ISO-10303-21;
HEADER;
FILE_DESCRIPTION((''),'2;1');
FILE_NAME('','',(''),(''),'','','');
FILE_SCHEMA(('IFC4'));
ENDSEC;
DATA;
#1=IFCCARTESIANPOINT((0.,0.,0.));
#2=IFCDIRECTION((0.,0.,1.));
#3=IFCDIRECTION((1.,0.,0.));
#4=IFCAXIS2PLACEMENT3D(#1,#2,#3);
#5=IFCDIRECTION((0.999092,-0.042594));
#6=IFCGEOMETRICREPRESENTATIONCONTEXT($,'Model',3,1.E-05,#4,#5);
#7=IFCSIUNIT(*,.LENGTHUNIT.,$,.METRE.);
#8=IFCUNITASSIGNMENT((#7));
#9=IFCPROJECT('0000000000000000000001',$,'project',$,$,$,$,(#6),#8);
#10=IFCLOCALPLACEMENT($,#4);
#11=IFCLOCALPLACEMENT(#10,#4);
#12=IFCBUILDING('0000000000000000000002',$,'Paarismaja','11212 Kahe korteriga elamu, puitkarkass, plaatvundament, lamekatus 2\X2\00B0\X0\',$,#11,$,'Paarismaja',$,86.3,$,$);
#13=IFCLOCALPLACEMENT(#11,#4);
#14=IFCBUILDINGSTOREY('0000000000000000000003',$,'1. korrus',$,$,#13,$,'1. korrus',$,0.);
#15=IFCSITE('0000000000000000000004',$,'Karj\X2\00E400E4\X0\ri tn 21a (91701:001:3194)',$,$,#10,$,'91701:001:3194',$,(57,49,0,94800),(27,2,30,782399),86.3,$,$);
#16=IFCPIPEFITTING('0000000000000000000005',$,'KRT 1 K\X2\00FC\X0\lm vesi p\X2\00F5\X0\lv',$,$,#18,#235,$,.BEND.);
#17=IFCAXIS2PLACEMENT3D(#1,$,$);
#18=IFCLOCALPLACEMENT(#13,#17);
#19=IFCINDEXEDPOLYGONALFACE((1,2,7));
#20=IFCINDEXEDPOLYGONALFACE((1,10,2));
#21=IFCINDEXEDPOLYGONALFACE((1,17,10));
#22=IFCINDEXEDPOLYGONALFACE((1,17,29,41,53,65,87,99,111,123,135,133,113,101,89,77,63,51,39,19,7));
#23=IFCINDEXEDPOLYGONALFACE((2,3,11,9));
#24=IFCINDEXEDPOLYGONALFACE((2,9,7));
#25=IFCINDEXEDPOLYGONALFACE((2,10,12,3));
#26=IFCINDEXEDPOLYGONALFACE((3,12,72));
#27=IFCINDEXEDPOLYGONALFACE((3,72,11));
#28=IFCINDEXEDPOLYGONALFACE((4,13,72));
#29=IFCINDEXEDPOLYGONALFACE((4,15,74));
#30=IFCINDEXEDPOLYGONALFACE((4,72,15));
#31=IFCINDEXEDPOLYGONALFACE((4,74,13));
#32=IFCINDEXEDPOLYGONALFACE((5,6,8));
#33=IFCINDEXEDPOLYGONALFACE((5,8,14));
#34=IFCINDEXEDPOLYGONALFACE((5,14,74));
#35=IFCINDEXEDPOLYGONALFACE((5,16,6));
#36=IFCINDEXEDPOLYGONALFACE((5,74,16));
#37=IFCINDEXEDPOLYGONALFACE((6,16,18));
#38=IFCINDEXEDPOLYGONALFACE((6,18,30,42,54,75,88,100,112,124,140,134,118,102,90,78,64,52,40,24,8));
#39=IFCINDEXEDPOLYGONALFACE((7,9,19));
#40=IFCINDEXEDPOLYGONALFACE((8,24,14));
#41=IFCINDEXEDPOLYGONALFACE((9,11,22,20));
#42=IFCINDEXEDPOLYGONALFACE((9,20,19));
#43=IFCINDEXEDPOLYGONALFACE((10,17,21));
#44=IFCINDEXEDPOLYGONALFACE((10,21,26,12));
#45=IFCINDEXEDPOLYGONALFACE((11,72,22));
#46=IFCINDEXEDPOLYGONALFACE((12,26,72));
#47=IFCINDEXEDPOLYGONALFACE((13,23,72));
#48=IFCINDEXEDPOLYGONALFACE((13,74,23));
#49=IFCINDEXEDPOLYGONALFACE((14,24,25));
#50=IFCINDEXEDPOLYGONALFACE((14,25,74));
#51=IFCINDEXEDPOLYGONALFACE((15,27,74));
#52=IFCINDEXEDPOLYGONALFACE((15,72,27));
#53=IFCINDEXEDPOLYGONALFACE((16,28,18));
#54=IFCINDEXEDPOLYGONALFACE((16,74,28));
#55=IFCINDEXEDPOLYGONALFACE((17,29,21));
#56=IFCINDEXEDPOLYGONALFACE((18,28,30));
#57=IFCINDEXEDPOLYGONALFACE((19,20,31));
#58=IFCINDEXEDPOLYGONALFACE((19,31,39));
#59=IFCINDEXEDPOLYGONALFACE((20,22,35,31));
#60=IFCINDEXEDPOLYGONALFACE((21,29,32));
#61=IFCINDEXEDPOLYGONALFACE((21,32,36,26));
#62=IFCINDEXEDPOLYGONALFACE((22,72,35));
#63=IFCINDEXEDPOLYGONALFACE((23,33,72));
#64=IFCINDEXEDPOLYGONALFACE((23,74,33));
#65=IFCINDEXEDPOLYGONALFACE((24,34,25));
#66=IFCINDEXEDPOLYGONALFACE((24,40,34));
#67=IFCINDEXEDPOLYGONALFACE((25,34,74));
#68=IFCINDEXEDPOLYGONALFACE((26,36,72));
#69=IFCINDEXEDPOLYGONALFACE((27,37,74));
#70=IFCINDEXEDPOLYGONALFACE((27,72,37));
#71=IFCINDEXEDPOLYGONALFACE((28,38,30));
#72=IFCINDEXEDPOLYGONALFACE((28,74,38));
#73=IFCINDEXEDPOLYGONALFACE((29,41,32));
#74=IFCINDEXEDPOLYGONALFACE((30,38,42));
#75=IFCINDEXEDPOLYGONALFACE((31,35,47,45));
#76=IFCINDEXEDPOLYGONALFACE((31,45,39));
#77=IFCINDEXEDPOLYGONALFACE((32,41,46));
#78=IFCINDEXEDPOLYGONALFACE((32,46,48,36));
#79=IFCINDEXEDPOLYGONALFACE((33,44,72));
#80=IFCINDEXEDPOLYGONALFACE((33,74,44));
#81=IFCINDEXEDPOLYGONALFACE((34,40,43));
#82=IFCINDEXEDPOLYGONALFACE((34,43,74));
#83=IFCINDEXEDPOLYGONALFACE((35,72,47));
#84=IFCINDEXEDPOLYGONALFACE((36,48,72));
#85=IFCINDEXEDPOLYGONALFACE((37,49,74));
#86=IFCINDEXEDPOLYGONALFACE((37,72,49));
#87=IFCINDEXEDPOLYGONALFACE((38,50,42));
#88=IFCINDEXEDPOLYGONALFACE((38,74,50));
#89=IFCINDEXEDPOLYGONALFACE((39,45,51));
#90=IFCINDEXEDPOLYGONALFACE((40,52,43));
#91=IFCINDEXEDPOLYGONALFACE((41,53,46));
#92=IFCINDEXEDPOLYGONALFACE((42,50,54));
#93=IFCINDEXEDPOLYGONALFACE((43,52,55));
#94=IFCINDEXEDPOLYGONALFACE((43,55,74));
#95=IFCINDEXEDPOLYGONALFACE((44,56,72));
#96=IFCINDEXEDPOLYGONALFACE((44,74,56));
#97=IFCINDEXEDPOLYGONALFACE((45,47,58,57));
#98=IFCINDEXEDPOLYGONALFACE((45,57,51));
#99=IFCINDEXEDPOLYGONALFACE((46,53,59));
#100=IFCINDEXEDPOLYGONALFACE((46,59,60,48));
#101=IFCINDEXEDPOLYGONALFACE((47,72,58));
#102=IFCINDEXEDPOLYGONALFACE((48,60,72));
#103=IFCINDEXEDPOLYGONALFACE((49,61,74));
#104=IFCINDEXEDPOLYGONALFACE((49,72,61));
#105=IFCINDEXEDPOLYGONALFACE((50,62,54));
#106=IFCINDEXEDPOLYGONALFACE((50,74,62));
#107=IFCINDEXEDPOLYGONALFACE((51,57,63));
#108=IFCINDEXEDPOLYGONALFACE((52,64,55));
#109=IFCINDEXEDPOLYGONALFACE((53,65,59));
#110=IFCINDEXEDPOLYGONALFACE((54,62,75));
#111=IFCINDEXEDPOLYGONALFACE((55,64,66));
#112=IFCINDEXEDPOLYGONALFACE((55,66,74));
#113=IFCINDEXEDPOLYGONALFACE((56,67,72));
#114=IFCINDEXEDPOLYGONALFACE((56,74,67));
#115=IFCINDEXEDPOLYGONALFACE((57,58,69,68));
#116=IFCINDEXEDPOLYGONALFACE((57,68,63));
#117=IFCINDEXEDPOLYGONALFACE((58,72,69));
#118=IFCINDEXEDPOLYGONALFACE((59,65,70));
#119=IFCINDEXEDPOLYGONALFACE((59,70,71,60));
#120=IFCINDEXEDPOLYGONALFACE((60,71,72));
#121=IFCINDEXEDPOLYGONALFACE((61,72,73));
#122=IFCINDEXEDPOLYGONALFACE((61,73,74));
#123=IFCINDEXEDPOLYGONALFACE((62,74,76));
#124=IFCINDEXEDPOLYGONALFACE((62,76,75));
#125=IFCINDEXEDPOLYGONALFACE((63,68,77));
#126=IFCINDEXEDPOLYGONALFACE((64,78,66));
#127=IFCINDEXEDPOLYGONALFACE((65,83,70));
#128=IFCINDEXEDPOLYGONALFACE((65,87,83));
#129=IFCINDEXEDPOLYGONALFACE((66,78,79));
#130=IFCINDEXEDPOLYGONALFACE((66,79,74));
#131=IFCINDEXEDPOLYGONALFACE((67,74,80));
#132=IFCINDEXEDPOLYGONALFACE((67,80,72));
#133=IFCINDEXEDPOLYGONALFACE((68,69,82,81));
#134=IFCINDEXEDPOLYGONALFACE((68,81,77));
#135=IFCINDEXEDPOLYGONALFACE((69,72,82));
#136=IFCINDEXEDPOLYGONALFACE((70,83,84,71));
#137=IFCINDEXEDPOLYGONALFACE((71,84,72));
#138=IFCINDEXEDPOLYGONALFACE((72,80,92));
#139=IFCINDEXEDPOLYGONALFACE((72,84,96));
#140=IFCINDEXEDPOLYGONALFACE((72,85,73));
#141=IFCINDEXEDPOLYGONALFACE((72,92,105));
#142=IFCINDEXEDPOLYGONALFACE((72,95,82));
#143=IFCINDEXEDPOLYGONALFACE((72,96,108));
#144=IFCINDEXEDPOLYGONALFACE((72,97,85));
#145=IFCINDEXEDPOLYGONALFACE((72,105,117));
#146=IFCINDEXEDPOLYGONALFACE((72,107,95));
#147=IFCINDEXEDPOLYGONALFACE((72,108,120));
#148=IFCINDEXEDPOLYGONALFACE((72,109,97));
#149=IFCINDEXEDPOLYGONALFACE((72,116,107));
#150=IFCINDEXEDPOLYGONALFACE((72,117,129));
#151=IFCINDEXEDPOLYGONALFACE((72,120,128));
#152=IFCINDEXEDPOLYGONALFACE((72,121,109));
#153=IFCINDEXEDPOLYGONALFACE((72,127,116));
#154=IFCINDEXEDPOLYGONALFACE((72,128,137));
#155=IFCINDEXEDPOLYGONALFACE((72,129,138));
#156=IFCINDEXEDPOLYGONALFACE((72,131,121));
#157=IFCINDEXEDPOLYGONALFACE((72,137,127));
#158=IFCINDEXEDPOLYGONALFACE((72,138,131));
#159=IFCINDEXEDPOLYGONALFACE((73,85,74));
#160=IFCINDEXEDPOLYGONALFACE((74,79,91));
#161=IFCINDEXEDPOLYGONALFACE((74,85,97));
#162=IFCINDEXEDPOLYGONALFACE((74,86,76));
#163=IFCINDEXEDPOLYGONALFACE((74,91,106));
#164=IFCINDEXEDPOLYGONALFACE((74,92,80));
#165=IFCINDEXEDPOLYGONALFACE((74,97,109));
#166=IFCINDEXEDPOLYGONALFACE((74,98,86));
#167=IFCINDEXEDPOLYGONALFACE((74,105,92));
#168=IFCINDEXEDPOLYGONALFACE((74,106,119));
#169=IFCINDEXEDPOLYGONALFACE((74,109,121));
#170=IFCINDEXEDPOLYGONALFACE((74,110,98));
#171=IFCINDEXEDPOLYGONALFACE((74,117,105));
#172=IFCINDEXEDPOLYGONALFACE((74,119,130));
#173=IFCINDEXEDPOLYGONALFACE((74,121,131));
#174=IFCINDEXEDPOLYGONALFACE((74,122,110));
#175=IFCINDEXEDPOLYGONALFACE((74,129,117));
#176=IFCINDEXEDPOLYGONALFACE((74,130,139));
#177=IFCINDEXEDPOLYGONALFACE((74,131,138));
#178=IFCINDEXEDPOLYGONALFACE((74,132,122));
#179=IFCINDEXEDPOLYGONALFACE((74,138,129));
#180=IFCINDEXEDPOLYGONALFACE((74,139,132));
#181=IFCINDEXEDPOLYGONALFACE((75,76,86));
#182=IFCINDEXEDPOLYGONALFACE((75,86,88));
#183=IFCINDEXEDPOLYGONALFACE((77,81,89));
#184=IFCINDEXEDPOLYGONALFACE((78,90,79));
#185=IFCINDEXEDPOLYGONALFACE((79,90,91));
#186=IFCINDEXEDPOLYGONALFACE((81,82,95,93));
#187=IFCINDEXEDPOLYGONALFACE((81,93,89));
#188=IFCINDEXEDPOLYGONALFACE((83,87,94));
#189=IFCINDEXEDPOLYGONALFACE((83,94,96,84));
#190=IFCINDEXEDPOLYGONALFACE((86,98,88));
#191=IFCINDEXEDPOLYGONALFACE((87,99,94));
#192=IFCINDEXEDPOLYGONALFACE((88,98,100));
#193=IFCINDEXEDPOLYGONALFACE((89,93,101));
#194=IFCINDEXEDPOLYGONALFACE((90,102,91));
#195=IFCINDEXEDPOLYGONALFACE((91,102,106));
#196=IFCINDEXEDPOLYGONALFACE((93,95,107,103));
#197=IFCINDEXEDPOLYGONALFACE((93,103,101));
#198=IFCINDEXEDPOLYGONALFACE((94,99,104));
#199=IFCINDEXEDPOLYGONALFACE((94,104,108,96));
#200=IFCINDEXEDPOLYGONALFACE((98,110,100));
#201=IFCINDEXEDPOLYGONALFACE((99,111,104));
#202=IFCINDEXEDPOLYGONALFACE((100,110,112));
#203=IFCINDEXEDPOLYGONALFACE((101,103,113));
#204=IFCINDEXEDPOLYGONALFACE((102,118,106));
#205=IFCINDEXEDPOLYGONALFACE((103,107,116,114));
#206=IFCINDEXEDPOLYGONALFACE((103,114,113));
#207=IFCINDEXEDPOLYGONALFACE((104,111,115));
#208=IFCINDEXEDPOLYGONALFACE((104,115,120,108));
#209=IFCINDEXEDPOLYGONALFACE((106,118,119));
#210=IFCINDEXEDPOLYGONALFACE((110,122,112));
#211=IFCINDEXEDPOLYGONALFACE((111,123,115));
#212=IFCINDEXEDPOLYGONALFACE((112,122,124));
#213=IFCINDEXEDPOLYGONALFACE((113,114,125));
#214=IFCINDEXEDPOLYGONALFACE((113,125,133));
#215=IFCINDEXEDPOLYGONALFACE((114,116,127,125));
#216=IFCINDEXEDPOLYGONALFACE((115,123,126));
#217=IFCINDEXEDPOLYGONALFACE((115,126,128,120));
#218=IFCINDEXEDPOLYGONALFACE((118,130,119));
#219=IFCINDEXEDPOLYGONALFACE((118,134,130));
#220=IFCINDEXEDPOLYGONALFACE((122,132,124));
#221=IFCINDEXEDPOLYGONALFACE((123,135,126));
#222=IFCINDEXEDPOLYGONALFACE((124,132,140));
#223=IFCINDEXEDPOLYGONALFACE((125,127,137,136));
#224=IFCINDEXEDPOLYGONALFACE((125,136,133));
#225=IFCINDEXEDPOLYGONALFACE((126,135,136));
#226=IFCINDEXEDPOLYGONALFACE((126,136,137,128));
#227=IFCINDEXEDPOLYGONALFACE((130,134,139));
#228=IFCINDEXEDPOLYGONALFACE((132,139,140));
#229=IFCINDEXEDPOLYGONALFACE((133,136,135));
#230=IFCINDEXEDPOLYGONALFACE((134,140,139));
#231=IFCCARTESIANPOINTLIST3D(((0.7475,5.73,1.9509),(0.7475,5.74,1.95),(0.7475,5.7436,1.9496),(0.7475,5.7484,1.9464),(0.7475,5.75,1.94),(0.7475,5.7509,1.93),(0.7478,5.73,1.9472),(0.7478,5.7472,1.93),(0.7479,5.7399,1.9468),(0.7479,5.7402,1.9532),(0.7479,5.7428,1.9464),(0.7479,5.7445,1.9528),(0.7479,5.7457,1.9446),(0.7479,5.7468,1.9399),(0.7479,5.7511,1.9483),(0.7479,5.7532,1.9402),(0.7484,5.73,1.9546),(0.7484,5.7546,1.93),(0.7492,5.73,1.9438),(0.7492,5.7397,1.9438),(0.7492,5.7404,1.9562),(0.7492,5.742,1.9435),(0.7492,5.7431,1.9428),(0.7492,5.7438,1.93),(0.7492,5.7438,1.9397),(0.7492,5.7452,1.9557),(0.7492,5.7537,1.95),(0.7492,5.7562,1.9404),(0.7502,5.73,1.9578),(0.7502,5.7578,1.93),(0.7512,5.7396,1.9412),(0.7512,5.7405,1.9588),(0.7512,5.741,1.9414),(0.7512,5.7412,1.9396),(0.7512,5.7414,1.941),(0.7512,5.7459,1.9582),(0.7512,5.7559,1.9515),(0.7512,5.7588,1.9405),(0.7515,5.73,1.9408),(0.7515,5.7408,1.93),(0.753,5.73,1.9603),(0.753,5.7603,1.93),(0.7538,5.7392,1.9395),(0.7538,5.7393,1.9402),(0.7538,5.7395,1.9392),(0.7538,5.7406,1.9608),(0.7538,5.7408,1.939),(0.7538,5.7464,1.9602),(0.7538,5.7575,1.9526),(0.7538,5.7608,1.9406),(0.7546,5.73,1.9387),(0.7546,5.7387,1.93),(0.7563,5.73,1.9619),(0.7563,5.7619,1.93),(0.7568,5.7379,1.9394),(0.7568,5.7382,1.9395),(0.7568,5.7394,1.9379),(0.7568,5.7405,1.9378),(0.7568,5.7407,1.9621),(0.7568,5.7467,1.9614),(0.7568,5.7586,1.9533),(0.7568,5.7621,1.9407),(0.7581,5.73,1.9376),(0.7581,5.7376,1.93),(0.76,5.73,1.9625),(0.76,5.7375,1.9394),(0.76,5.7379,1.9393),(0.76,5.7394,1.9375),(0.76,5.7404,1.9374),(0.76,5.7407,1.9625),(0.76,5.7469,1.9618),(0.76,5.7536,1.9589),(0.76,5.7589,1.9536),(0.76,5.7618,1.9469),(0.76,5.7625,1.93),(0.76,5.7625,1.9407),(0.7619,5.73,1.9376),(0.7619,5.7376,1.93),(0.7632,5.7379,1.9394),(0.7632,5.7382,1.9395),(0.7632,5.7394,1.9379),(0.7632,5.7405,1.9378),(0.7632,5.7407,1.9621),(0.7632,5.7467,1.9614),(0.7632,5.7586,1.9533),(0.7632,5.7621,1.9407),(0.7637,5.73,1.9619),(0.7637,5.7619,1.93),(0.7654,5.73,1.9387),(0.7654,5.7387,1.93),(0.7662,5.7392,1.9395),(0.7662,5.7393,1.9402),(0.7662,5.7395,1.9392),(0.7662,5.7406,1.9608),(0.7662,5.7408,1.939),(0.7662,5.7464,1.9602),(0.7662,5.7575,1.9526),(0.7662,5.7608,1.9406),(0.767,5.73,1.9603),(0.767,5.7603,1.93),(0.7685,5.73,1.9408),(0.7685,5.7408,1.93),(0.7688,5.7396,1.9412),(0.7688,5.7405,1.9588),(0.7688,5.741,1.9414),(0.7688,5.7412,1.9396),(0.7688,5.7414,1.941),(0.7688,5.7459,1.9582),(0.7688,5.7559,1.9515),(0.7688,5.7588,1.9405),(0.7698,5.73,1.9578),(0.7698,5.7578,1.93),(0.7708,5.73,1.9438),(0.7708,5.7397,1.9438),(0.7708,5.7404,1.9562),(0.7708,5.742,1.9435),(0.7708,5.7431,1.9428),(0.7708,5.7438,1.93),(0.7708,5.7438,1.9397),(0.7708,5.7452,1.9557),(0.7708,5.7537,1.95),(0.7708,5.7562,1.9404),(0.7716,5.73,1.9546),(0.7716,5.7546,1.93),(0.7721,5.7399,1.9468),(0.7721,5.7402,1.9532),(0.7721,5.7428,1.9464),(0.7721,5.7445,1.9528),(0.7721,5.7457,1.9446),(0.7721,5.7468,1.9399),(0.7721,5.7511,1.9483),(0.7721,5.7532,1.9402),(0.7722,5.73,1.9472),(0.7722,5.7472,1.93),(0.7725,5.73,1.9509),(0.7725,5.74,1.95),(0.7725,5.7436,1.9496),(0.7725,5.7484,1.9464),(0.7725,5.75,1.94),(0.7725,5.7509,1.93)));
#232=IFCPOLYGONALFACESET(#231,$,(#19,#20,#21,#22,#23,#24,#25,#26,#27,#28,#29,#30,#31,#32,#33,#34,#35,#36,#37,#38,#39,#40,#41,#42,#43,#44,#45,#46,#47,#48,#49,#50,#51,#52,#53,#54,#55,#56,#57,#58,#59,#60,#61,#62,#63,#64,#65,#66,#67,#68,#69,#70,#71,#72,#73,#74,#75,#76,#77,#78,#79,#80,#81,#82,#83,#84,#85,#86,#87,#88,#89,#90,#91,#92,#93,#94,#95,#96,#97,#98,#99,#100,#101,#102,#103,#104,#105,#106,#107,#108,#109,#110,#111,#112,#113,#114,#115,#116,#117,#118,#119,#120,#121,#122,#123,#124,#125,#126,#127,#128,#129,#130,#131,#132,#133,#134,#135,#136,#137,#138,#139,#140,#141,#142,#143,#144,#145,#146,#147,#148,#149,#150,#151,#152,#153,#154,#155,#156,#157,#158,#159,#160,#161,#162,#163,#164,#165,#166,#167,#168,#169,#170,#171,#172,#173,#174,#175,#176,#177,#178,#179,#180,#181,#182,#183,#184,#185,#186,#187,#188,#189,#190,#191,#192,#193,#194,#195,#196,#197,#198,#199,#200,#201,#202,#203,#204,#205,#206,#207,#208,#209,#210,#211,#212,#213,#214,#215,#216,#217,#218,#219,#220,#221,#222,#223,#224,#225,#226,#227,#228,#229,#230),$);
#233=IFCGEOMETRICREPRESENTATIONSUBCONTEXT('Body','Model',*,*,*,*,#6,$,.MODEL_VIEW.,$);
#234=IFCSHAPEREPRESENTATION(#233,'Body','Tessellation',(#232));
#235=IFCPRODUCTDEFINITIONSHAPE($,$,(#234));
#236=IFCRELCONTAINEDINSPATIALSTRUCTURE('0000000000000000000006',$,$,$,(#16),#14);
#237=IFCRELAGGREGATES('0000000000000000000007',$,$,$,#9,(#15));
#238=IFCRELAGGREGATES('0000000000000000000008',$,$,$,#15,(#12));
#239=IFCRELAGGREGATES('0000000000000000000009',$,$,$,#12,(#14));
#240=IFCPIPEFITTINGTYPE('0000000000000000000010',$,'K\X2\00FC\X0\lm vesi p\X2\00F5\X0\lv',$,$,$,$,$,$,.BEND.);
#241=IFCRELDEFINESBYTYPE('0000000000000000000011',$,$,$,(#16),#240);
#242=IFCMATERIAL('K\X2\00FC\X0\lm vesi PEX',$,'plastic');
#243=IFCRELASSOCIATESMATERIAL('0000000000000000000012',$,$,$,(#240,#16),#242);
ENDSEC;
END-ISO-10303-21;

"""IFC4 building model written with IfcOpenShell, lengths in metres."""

from ifc_helpers import new_model, entity, si_unit, direction, frame, origin_with_axes, place, context, subcontext, project, spatial, material, type_object, element, save


model = new_model("IFC4")

# Units and contexts
model_context = context("Model", 3, precision=1e-05, world=origin_with_axes(), true_north=direction((0.999092, -0.042594)))
body_context = subcontext(model_context, "Body", "Model", "MODEL_VIEW")
ifc_project = project(units=[si_unit("LENGTHUNIT", "METRE")], contexts=[model_context])

# Site, building, storey
site_placement = place(None, origin_with_axes())
site = spatial("IfcSite", under=ifc_project, at=site_placement, Name="Karjääri tn 21a (91701:001:3194)", LongName="91701:001:3194", RefLatitude=(57, 49, 0, 94800), RefLongitude=(27, 2, 30, 782399), RefElevation=86.3)
building_placement = place(site_placement, origin_with_axes())
building = spatial("IfcBuilding", under=site, at=building_placement, Name="Paarismaja", Description="11212 Kahe korteriga elamu, puitkarkass, plaatvundament, lamekatus 2°", LongName="Paarismaja", ElevationOfRefHeight=86.3)
storey_placement = place(building_placement, origin_with_axes())
storey = spatial("IfcBuildingStorey", under=building, at=storey_placement, Name="1. korrus", LongName="1. korrus", Elevation=0.0)

# Pipe fitting
ifc_material_1 = material(Name="Külm vesi PEX", Category="plastic")
pipe_fitting_type_1 = type_object("IfcPipeFittingType", Name="Külm vesi põlv", PredefinedType="BEND", material=ifc_material_1)
pipe_fitting_1_placement = place(storey_placement, frame((0.76, 5.75, 1.95), z_axis=(0.0, 0.0, 1.0), x_axis=(1.0, 0.0, 0.0)))
element("IfcPipeFitting", 1, at=pipe_fitting_1_placement, inside=storey, type_object=pipe_fitting_type_1, material=ifc_material_1, Name="KRT 1 Külm vesi põlv", PredefinedType="BEND", context=body_context, shape_type="AdvancedSweptSolid", body=[
    entity("IfcSweptDiskSolid", entity("IfcIndexedPolyCurve", entity("IfcCartesianPointList3D", [[0.0, -0.02, 0.0], [0.0, -0.01, 0.0], [0.0, -0.0064, -0.0004], [0.0, -0.0036, -0.0016], [0.0, -0.0016, -0.0036], [0.0, -0.0004, -0.0064], [0.0, 0.0, -0.01], [0.0, 0.0, -0.02]]), None, False), 0.0125),
])

save(model, "model.ifc")
